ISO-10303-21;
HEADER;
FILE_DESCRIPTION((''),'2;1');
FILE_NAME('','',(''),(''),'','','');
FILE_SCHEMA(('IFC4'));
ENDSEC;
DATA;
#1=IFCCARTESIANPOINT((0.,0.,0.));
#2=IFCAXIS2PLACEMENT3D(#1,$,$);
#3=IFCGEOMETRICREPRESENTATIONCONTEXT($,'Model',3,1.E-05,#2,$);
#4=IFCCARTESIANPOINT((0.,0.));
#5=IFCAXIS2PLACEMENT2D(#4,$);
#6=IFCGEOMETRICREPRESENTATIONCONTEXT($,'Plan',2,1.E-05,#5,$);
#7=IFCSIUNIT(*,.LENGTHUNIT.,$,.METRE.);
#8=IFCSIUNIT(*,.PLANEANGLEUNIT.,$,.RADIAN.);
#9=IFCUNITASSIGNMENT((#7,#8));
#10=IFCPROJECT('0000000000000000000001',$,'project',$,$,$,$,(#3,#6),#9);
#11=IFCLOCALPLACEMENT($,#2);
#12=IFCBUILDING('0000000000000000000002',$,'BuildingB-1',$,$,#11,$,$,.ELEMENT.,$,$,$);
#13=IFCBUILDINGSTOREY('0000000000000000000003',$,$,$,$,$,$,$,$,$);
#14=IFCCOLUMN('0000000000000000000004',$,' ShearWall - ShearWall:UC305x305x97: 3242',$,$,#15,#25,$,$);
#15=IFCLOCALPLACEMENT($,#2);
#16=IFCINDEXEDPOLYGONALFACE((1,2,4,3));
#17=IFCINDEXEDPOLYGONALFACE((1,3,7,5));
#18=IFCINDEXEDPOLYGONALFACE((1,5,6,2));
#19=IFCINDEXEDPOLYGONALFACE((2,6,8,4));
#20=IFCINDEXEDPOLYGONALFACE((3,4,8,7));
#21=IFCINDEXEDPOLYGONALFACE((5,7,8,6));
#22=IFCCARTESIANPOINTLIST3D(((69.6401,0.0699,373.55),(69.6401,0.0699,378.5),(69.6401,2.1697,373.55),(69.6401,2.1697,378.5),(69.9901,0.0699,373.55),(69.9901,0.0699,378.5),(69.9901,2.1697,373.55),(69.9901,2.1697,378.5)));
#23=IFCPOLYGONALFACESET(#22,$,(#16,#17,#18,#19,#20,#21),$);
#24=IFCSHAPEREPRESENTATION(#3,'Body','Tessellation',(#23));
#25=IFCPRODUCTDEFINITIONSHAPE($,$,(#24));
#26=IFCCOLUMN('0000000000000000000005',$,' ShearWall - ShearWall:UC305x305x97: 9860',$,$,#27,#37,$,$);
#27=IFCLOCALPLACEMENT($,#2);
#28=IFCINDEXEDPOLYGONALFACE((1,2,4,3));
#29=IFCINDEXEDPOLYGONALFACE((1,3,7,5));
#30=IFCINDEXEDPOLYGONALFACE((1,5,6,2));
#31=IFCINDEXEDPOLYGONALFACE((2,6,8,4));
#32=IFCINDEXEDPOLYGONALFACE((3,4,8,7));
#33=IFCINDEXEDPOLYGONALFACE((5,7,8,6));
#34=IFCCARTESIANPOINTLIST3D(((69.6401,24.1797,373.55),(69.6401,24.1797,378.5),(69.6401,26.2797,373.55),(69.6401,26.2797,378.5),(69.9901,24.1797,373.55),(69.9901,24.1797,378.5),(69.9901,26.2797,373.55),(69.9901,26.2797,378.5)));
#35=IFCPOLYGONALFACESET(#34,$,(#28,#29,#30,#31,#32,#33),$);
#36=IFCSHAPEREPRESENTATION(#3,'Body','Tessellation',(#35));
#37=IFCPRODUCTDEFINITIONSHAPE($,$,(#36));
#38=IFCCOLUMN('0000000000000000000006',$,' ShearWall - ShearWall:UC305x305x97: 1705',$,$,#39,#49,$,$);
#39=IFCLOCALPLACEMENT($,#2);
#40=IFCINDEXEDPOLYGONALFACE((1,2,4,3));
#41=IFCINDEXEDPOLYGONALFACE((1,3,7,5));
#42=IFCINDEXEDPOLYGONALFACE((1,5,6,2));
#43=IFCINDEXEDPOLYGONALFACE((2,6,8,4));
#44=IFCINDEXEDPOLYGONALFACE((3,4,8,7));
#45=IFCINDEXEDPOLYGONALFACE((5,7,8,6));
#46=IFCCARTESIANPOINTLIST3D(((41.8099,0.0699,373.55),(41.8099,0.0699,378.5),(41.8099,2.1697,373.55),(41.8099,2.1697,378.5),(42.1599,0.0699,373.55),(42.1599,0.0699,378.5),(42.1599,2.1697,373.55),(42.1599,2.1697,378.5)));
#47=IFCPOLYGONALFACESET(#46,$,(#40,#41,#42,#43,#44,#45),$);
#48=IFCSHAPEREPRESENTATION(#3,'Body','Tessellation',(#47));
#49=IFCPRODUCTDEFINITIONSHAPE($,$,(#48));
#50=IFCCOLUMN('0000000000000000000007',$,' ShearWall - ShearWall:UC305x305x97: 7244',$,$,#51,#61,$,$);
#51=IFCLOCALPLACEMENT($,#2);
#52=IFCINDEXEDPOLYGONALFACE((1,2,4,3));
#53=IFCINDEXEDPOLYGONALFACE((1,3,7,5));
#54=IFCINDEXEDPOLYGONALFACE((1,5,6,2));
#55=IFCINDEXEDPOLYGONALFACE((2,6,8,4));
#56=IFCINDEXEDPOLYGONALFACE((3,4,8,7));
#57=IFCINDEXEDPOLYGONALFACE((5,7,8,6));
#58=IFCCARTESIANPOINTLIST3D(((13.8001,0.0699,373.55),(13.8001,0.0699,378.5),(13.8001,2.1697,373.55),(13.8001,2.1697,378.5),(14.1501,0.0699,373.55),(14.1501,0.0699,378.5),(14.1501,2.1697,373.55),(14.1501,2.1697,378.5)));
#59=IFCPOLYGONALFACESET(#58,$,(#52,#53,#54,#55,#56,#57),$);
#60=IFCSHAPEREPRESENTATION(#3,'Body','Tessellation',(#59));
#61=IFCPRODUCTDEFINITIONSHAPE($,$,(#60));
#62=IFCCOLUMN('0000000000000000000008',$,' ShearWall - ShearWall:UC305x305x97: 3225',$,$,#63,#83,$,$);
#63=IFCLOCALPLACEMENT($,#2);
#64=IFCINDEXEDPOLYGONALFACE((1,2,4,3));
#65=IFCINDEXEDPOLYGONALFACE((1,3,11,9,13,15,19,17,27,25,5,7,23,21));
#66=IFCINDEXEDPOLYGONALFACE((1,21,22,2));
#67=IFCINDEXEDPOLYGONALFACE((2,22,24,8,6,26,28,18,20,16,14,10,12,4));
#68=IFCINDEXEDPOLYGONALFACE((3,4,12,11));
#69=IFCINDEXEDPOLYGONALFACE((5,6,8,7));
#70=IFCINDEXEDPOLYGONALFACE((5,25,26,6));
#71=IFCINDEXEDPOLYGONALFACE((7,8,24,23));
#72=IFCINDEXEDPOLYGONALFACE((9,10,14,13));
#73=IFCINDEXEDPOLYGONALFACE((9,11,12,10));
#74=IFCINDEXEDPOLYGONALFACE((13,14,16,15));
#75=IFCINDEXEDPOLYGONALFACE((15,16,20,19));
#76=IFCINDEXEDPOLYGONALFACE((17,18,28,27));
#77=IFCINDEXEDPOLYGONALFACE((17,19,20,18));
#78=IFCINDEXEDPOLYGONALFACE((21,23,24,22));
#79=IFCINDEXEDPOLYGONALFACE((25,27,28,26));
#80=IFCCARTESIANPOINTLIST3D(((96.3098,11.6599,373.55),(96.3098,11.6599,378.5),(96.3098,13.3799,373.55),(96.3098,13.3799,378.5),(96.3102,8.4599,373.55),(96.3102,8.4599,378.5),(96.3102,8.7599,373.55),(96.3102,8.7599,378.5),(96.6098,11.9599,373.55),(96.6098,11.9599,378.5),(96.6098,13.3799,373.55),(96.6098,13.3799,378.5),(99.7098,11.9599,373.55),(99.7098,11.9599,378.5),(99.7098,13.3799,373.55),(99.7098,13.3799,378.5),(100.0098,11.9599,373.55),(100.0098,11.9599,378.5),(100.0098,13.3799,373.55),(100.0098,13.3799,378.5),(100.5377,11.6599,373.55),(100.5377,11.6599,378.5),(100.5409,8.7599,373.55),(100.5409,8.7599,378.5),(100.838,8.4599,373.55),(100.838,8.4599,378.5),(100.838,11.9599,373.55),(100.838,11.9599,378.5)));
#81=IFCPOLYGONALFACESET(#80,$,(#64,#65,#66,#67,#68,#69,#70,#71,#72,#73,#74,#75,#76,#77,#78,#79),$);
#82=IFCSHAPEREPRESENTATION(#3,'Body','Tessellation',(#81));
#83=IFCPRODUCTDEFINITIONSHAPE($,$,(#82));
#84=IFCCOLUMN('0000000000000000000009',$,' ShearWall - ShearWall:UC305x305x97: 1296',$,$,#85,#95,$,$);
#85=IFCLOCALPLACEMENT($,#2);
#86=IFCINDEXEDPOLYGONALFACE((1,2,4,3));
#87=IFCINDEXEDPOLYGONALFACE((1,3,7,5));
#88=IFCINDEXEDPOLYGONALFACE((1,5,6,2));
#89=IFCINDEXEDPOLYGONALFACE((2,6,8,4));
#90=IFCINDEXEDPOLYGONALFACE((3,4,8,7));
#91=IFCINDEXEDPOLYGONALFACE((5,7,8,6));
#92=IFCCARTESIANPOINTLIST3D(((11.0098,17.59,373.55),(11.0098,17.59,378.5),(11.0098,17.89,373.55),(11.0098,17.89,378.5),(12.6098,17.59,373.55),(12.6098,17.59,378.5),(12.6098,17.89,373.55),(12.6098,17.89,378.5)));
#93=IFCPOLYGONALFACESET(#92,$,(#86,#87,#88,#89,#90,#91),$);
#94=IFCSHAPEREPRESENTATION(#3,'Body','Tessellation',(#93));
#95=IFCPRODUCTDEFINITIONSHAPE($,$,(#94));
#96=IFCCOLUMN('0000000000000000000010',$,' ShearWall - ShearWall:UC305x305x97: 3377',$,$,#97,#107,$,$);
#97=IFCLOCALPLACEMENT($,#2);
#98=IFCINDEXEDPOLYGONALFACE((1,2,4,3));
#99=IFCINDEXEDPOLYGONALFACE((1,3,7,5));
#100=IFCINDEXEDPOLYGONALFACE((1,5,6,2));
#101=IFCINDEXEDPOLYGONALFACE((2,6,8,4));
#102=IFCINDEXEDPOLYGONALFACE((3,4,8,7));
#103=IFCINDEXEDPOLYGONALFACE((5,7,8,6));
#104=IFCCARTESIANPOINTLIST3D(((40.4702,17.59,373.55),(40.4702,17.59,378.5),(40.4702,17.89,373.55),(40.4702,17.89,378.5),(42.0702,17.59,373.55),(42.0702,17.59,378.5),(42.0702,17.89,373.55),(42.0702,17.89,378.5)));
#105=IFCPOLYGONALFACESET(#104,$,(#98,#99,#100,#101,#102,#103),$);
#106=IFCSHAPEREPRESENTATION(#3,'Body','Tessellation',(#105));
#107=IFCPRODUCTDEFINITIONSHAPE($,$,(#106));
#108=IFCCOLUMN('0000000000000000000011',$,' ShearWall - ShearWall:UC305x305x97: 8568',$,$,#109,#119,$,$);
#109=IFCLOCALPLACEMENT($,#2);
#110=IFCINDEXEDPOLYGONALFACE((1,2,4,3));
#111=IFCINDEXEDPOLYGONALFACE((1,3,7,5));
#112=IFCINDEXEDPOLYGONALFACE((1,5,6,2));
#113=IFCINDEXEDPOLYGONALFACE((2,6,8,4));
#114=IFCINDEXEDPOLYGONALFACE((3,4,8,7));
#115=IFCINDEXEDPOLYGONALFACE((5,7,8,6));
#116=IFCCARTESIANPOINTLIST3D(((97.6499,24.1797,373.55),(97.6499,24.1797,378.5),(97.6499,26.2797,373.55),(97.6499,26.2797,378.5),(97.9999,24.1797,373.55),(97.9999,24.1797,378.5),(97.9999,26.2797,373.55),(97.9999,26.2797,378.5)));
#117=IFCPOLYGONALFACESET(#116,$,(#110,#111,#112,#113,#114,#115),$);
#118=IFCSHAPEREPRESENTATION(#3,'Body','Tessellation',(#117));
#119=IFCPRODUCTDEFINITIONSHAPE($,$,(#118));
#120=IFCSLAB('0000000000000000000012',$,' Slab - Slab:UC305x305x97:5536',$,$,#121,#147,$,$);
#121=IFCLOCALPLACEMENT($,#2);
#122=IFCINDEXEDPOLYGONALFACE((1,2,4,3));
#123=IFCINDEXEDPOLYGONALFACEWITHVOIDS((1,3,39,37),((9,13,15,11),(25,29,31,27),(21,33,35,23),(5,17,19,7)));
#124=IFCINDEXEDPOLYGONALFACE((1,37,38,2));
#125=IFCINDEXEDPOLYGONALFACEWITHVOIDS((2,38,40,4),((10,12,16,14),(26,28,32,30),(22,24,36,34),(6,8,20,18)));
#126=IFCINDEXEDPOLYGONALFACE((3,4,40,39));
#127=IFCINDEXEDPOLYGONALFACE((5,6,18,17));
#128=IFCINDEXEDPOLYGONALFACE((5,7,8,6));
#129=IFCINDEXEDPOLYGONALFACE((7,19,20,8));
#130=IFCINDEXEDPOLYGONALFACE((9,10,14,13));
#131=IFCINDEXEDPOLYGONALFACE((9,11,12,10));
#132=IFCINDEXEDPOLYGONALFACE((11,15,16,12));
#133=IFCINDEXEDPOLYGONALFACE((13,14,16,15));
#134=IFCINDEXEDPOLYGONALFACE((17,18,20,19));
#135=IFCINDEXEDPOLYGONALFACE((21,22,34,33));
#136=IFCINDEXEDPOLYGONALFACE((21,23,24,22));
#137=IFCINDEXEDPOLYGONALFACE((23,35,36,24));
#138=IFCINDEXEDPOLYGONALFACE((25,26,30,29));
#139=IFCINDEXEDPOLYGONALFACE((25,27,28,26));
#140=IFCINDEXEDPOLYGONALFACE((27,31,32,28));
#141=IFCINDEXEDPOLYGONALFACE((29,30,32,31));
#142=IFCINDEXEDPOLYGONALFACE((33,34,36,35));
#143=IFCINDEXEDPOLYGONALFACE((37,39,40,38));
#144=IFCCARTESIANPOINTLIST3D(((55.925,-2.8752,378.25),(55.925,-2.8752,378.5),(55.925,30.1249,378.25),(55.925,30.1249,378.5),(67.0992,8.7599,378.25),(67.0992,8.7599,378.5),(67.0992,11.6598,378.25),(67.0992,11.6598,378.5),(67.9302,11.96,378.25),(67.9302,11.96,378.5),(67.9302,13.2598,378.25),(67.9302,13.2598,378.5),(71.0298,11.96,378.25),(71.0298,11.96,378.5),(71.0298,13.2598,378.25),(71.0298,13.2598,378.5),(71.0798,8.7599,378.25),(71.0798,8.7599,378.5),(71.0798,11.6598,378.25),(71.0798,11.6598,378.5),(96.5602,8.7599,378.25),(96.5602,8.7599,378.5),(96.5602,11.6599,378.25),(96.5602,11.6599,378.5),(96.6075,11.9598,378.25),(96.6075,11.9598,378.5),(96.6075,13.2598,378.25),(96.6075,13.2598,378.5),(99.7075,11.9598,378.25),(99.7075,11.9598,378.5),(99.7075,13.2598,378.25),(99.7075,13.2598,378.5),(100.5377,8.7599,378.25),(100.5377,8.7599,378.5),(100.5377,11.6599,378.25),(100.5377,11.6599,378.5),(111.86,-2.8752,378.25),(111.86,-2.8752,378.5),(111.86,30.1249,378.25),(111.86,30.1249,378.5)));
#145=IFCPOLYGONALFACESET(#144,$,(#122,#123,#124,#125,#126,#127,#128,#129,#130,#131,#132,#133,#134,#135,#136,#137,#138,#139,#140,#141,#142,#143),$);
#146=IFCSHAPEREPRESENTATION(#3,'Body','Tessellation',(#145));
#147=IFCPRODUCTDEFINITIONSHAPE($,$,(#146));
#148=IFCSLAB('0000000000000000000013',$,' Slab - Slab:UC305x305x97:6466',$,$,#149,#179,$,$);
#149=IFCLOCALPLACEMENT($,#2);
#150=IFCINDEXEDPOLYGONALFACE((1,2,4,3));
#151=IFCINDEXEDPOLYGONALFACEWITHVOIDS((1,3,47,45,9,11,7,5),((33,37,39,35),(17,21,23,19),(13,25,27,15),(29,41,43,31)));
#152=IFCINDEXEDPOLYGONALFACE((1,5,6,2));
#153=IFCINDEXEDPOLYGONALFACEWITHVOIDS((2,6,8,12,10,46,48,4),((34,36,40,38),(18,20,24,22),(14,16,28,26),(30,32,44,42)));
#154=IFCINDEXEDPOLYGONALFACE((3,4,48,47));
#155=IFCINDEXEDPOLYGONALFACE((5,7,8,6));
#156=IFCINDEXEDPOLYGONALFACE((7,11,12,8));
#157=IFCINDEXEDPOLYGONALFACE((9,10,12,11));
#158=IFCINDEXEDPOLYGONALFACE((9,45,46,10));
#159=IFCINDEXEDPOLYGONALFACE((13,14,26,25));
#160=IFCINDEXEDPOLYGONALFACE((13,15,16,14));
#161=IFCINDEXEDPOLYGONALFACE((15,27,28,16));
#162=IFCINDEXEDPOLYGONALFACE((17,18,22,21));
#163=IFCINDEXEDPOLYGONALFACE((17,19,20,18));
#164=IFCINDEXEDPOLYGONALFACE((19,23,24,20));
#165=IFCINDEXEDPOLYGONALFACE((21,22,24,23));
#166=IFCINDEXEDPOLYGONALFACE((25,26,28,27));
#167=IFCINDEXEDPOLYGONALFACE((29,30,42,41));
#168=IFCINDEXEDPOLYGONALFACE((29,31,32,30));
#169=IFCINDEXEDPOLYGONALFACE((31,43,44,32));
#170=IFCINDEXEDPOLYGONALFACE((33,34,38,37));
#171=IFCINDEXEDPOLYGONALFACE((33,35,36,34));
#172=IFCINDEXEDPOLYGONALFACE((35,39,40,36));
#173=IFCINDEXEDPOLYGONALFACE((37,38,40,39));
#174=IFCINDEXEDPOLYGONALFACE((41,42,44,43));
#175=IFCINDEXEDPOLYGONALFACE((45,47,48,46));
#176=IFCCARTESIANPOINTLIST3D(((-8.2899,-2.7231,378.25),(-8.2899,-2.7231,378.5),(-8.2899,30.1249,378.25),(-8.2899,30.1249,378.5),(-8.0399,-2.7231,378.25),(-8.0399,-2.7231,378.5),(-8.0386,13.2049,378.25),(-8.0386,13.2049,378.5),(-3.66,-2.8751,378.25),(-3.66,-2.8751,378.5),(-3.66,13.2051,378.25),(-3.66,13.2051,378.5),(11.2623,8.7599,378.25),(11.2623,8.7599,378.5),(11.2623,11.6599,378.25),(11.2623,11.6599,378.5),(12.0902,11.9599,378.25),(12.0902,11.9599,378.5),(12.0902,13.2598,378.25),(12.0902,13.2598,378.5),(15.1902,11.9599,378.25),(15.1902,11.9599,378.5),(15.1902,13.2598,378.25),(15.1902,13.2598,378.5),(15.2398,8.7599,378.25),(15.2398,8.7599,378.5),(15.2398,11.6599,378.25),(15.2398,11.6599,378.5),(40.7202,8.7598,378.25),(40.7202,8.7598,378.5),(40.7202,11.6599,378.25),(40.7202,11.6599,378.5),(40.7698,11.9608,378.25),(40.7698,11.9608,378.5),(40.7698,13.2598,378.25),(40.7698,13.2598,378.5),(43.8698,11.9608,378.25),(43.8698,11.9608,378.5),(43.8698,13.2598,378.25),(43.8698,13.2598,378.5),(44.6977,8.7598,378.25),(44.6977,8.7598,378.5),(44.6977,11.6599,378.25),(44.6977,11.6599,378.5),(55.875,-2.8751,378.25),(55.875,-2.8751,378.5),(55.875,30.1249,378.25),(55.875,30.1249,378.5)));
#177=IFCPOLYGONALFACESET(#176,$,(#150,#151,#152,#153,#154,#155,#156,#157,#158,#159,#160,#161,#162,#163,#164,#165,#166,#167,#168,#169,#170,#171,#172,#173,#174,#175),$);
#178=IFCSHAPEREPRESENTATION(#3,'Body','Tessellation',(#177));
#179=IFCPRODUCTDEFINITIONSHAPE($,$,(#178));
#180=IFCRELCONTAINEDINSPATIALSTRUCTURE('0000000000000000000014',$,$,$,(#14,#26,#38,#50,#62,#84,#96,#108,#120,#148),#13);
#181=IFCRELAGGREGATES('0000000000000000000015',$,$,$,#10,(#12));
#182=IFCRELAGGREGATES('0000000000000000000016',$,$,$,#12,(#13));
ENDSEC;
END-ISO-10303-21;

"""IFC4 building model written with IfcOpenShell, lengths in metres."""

from ifc_helpers import new_model, si_unit, origin, origin_with_axes, origin_2d, place, context, project, spatial, polyline, outline, extrude, element, save


model = new_model("IFC4")

# Units and contexts
model_context = context("Model", 3, precision=1e-05, world=origin())
plan_context = context("Plan", 2, precision=1e-05, world=origin_2d())
ifc_project = project(units=[si_unit("LENGTHUNIT", "METRE"), si_unit("PLANEANGLEUNIT", "RADIAN")], contexts=[model_context, plan_context])

# Building, storey
building_placement = place(None, origin())
building = spatial("IfcBuilding", under=ifc_project, at=building_placement, Name="BuildingB-1", CompositionType="ELEMENT")
storey = spatial("IfcBuildingStorey", under=building)

# Columns
column_1_placement = place(None, origin_with_axes())
element("IfcColumn", 1, at=column_1_placement, inside=storey, Name=" ShearWall - ShearWall:UC305x305x97: 3242", context=model_context, shape_type="SweptSolid", body=[
    extrude(outline(polyline([(69.9901, 2.1697, 378.5), (69.6401, 2.1697, 378.5), (69.6401, 0.0699, 378.5), (69.9901, 0.0699, 378.5), (69.9901, 2.1697, 378.5)])), None, (0.0, 0.0, -1.0), 4.95),
])
column_2_placement = place(None, origin_with_axes())
element("IfcColumn", 2, at=column_2_placement, inside=storey, Name=" ShearWall - ShearWall:UC305x305x97: 9860", context=model_context, shape_type="SweptSolid", body=[
    extrude(outline(polyline([(69.9901, 26.2797, 378.5), (69.6401, 26.2797, 378.5), (69.6401, 24.1797, 378.5), (69.9901, 24.1797, 378.5), (69.9901, 26.2797, 378.5)])), None, (0.0, 0.0, -1.0), 4.95),
])
column_3_placement = place(None, origin_with_axes())
element("IfcColumn", 3, at=column_3_placement, inside=storey, Name=" ShearWall - ShearWall:UC305x305x97: 1705", context=model_context, shape_type="SweptSolid", body=[
    extrude(outline(polyline([(41.8099, 2.1697, 378.5), (42.1599, 2.1697, 378.5), (42.1599, 0.0699, 378.5), (41.8099, 0.0699, 378.5), (41.8099, 2.1697, 378.5)])), None, (0.0, 0.0, -1.0), 4.95),
])
column_4_placement = place(None, origin_with_axes())
element("IfcColumn", 4, at=column_4_placement, inside=storey, Name=" ShearWall - ShearWall:UC305x305x97: 7244", context=model_context, shape_type="SweptSolid", body=[
    extrude(outline(polyline([(14.1501, 2.1697, 378.5), (13.8001, 2.1697, 378.5), (13.8001, 0.0699, 378.5), (14.1501, 0.0699, 378.5), (14.1501, 2.1697, 378.5)])), None, (0.0, 0.0, -1.0), 4.95),
])
column_5_placement = place(None, origin_with_axes())
element("IfcColumn", 5, at=column_5_placement, inside=storey, Name=" ShearWall - ShearWall:UC305x305x97: 3225", context=model_context, shape_type="SweptSolid", body=[
    extrude(outline(polyline([(100.838, 8.4599, 378.5), (96.3102, 8.4599, 378.5), (96.3102, 8.7599, 378.5), (100.5409, 8.7599, 378.5), (100.5377, 11.6599, 378.5), (96.3098, 11.6599, 378.5), (96.3098, 13.3799, 378.5), (96.6098, 13.3799, 378.5), (96.6098, 11.9599, 378.5), (99.7098, 11.9599, 378.5), (99.7098, 13.3799, 378.5), (100.0098, 13.3799, 378.5), (100.0098, 11.9599, 378.5), (100.838, 11.9599, 378.5), (100.838, 8.4599, 378.5)])), None, (0.0, 0.0, -1.0), 4.95),
])
column_6_placement = place(None, origin_with_axes())
element("IfcColumn", 6, at=column_6_placement, inside=storey, Name=" ShearWall - ShearWall:UC305x305x97: 1296", context=model_context, shape_type="SweptSolid", body=[
    extrude(outline(polyline([(11.0098, 17.59, 378.5), (11.0098, 17.89, 378.5), (12.6098, 17.89, 378.5), (12.6098, 17.59, 378.5), (11.0098, 17.59, 378.5)])), None, (0.0, 0.0, -1.0), 4.95),
])
column_7_placement = place(None, origin_with_axes())
element("IfcColumn", 7, at=column_7_placement, inside=storey, Name=" ShearWall - ShearWall:UC305x305x97: 3377", context=model_context, shape_type="SweptSolid", body=[
    extrude(outline(polyline([(42.0702, 17.59, 378.5), (42.0702, 17.89, 378.5), (40.4702, 17.89, 378.5), (40.4702, 17.59, 378.5), (42.0702, 17.59, 378.5)])), None, (0.0, 0.0, -1.0), 4.95),
])
column_8_placement = place(None, origin_with_axes())
element("IfcColumn", 8, at=column_8_placement, inside=storey, Name=" ShearWall - ShearWall:UC305x305x97: 8568", context=model_context, shape_type="SweptSolid", body=[
    extrude(outline(polyline([(97.6499, 26.2797, 378.5), (97.9999, 26.2797, 378.5), (97.9999, 24.1797, 378.5), (97.6499, 24.1797, 378.5), (97.6499, 26.2797, 378.5)])), None, (0.0, 0.0, -1.0), 4.95),
])

# Slabs, openings
slab_1 = element("IfcSlab", 9, inside=storey, Name=" Slab - Slab:UC305x305x97:5536", context=model_context, shape_type="SweptSolid", body=[
    extrude(outline(polyline([(111.86, 30.1249, 378.5), (55.925, 30.1249, 378.5), (55.925, -2.8752, 378.5), (111.86, -2.8752, 378.5), (111.86, 30.1249, 378.5)])), None, (0.0, 0.0, -1.0), 0.25),
])
element("IfcOpeningElement", 10, inside=storey, cuts=slab_1, context=model_context, shape_type="SweptSolid", body=[
    extrude(outline(polyline([(67.0992, 8.7599, 378.5), (71.0798, 8.7599, 378.5), (71.0798, 11.6598, 378.5), (67.0992, 11.6598, 378.5), (67.0992, 8.7599, 378.5)])), None, (0.0, 0.0, -1.0), 0.275),
])
element("IfcOpeningElement", 11, inside=storey, cuts=slab_1, context=model_context, shape_type="SweptSolid", body=[
    extrude(outline(polyline([(67.9302, 11.96, 378.5), (71.0298, 11.96, 378.5), (71.0298, 13.2598, 378.5), (67.9302, 13.2598, 378.5), (67.9302, 11.96, 378.5)])), None, (0.0, 0.0, -1.0), 0.275),
])
element("IfcOpeningElement", 12, inside=storey, cuts=slab_1, context=model_context, shape_type="SweptSolid", body=[
    extrude(outline(polyline([(96.5602, 8.7599, 378.5), (100.5377, 8.7599, 378.5), (100.5377, 11.6599, 378.5), (96.5602, 11.6599, 378.5), (96.5602, 8.7599, 378.5)])), None, (0.0, 0.0, -1.0), 0.275),
])
element("IfcOpeningElement", 13, inside=storey, cuts=slab_1, context=model_context, shape_type="SweptSolid", body=[
    extrude(outline(polyline([(96.6075, 11.9598, 378.5), (99.7075, 11.9598, 378.5), (99.7075, 13.2598, 378.5), (96.6075, 13.2598, 378.5), (96.6075, 11.9598, 378.5)])), None, (0.0, 0.0, -1.0), 0.275),
])
slab_2 = element("IfcSlab", 14, inside=storey, Name=" Slab - Slab:UC305x305x97:6466", context=model_context, shape_type="SweptSolid", body=[
    extrude(outline(polyline([(55.875, 30.1249, 378.5), (55.875, -2.8751, 378.5), (-3.66, -2.8751, 378.5), (-3.66, 13.2051, 378.5), (-8.0386, 13.2049, 378.5), (-8.0399, -2.7231, 378.5), (-8.2899, -2.7231, 378.5), (-8.2899, 30.1249, 378.5), (55.875, 30.1249, 378.5)])), None, (0.0, 0.0, -1.0), 0.25),
])
element("IfcOpeningElement", 15, inside=storey, cuts=slab_2, context=model_context, shape_type="SweptSolid", body=[
    extrude(outline(polyline([(12.0902, 11.9599, 378.5), (15.1902, 11.9599, 378.5), (15.1902, 13.2598, 378.5), (12.0902, 13.2598, 378.5), (12.0902, 11.9599, 378.5)])), None, (0.0, 0.0, -1.0), 0.275),
])
element("IfcOpeningElement", 16, inside=storey, cuts=slab_2, context=model_context, shape_type="SweptSolid", body=[
    extrude(outline(polyline([(11.2623, 11.6599, 378.5), (15.2398, 11.6599, 378.5), (15.2398, 8.7599, 378.5), (11.2623, 8.7599, 378.5), (11.2623, 11.6599, 378.5)])), None, (0.0, 0.0, -1.0), 0.275),
])
element("IfcOpeningElement", 17, inside=storey, cuts=slab_2, context=model_context, shape_type="SweptSolid", body=[
    extrude(outline(polyline([(40.7698, 11.9608, 378.5), (43.8698, 11.9608, 378.5), (43.8698, 13.2598, 378.5), (40.7698, 13.2598, 378.5), (40.7698, 11.9608, 378.5)])), None, (0.0, 0.0, -1.0), 0.275),
])
element("IfcOpeningElement", 18, inside=storey, cuts=slab_2, context=model_context, shape_type="SweptSolid", body=[
    extrude(outline(polyline([(40.7202, 8.7598, 378.5), (44.6977, 8.7598, 378.5), (44.6977, 11.6599, 378.5), (40.7202, 11.6599, 378.5), (40.7202, 8.7598, 378.5)])), None, (0.0, 0.0, -1.0), 0.275),
])

save(model, "model.ifc")
